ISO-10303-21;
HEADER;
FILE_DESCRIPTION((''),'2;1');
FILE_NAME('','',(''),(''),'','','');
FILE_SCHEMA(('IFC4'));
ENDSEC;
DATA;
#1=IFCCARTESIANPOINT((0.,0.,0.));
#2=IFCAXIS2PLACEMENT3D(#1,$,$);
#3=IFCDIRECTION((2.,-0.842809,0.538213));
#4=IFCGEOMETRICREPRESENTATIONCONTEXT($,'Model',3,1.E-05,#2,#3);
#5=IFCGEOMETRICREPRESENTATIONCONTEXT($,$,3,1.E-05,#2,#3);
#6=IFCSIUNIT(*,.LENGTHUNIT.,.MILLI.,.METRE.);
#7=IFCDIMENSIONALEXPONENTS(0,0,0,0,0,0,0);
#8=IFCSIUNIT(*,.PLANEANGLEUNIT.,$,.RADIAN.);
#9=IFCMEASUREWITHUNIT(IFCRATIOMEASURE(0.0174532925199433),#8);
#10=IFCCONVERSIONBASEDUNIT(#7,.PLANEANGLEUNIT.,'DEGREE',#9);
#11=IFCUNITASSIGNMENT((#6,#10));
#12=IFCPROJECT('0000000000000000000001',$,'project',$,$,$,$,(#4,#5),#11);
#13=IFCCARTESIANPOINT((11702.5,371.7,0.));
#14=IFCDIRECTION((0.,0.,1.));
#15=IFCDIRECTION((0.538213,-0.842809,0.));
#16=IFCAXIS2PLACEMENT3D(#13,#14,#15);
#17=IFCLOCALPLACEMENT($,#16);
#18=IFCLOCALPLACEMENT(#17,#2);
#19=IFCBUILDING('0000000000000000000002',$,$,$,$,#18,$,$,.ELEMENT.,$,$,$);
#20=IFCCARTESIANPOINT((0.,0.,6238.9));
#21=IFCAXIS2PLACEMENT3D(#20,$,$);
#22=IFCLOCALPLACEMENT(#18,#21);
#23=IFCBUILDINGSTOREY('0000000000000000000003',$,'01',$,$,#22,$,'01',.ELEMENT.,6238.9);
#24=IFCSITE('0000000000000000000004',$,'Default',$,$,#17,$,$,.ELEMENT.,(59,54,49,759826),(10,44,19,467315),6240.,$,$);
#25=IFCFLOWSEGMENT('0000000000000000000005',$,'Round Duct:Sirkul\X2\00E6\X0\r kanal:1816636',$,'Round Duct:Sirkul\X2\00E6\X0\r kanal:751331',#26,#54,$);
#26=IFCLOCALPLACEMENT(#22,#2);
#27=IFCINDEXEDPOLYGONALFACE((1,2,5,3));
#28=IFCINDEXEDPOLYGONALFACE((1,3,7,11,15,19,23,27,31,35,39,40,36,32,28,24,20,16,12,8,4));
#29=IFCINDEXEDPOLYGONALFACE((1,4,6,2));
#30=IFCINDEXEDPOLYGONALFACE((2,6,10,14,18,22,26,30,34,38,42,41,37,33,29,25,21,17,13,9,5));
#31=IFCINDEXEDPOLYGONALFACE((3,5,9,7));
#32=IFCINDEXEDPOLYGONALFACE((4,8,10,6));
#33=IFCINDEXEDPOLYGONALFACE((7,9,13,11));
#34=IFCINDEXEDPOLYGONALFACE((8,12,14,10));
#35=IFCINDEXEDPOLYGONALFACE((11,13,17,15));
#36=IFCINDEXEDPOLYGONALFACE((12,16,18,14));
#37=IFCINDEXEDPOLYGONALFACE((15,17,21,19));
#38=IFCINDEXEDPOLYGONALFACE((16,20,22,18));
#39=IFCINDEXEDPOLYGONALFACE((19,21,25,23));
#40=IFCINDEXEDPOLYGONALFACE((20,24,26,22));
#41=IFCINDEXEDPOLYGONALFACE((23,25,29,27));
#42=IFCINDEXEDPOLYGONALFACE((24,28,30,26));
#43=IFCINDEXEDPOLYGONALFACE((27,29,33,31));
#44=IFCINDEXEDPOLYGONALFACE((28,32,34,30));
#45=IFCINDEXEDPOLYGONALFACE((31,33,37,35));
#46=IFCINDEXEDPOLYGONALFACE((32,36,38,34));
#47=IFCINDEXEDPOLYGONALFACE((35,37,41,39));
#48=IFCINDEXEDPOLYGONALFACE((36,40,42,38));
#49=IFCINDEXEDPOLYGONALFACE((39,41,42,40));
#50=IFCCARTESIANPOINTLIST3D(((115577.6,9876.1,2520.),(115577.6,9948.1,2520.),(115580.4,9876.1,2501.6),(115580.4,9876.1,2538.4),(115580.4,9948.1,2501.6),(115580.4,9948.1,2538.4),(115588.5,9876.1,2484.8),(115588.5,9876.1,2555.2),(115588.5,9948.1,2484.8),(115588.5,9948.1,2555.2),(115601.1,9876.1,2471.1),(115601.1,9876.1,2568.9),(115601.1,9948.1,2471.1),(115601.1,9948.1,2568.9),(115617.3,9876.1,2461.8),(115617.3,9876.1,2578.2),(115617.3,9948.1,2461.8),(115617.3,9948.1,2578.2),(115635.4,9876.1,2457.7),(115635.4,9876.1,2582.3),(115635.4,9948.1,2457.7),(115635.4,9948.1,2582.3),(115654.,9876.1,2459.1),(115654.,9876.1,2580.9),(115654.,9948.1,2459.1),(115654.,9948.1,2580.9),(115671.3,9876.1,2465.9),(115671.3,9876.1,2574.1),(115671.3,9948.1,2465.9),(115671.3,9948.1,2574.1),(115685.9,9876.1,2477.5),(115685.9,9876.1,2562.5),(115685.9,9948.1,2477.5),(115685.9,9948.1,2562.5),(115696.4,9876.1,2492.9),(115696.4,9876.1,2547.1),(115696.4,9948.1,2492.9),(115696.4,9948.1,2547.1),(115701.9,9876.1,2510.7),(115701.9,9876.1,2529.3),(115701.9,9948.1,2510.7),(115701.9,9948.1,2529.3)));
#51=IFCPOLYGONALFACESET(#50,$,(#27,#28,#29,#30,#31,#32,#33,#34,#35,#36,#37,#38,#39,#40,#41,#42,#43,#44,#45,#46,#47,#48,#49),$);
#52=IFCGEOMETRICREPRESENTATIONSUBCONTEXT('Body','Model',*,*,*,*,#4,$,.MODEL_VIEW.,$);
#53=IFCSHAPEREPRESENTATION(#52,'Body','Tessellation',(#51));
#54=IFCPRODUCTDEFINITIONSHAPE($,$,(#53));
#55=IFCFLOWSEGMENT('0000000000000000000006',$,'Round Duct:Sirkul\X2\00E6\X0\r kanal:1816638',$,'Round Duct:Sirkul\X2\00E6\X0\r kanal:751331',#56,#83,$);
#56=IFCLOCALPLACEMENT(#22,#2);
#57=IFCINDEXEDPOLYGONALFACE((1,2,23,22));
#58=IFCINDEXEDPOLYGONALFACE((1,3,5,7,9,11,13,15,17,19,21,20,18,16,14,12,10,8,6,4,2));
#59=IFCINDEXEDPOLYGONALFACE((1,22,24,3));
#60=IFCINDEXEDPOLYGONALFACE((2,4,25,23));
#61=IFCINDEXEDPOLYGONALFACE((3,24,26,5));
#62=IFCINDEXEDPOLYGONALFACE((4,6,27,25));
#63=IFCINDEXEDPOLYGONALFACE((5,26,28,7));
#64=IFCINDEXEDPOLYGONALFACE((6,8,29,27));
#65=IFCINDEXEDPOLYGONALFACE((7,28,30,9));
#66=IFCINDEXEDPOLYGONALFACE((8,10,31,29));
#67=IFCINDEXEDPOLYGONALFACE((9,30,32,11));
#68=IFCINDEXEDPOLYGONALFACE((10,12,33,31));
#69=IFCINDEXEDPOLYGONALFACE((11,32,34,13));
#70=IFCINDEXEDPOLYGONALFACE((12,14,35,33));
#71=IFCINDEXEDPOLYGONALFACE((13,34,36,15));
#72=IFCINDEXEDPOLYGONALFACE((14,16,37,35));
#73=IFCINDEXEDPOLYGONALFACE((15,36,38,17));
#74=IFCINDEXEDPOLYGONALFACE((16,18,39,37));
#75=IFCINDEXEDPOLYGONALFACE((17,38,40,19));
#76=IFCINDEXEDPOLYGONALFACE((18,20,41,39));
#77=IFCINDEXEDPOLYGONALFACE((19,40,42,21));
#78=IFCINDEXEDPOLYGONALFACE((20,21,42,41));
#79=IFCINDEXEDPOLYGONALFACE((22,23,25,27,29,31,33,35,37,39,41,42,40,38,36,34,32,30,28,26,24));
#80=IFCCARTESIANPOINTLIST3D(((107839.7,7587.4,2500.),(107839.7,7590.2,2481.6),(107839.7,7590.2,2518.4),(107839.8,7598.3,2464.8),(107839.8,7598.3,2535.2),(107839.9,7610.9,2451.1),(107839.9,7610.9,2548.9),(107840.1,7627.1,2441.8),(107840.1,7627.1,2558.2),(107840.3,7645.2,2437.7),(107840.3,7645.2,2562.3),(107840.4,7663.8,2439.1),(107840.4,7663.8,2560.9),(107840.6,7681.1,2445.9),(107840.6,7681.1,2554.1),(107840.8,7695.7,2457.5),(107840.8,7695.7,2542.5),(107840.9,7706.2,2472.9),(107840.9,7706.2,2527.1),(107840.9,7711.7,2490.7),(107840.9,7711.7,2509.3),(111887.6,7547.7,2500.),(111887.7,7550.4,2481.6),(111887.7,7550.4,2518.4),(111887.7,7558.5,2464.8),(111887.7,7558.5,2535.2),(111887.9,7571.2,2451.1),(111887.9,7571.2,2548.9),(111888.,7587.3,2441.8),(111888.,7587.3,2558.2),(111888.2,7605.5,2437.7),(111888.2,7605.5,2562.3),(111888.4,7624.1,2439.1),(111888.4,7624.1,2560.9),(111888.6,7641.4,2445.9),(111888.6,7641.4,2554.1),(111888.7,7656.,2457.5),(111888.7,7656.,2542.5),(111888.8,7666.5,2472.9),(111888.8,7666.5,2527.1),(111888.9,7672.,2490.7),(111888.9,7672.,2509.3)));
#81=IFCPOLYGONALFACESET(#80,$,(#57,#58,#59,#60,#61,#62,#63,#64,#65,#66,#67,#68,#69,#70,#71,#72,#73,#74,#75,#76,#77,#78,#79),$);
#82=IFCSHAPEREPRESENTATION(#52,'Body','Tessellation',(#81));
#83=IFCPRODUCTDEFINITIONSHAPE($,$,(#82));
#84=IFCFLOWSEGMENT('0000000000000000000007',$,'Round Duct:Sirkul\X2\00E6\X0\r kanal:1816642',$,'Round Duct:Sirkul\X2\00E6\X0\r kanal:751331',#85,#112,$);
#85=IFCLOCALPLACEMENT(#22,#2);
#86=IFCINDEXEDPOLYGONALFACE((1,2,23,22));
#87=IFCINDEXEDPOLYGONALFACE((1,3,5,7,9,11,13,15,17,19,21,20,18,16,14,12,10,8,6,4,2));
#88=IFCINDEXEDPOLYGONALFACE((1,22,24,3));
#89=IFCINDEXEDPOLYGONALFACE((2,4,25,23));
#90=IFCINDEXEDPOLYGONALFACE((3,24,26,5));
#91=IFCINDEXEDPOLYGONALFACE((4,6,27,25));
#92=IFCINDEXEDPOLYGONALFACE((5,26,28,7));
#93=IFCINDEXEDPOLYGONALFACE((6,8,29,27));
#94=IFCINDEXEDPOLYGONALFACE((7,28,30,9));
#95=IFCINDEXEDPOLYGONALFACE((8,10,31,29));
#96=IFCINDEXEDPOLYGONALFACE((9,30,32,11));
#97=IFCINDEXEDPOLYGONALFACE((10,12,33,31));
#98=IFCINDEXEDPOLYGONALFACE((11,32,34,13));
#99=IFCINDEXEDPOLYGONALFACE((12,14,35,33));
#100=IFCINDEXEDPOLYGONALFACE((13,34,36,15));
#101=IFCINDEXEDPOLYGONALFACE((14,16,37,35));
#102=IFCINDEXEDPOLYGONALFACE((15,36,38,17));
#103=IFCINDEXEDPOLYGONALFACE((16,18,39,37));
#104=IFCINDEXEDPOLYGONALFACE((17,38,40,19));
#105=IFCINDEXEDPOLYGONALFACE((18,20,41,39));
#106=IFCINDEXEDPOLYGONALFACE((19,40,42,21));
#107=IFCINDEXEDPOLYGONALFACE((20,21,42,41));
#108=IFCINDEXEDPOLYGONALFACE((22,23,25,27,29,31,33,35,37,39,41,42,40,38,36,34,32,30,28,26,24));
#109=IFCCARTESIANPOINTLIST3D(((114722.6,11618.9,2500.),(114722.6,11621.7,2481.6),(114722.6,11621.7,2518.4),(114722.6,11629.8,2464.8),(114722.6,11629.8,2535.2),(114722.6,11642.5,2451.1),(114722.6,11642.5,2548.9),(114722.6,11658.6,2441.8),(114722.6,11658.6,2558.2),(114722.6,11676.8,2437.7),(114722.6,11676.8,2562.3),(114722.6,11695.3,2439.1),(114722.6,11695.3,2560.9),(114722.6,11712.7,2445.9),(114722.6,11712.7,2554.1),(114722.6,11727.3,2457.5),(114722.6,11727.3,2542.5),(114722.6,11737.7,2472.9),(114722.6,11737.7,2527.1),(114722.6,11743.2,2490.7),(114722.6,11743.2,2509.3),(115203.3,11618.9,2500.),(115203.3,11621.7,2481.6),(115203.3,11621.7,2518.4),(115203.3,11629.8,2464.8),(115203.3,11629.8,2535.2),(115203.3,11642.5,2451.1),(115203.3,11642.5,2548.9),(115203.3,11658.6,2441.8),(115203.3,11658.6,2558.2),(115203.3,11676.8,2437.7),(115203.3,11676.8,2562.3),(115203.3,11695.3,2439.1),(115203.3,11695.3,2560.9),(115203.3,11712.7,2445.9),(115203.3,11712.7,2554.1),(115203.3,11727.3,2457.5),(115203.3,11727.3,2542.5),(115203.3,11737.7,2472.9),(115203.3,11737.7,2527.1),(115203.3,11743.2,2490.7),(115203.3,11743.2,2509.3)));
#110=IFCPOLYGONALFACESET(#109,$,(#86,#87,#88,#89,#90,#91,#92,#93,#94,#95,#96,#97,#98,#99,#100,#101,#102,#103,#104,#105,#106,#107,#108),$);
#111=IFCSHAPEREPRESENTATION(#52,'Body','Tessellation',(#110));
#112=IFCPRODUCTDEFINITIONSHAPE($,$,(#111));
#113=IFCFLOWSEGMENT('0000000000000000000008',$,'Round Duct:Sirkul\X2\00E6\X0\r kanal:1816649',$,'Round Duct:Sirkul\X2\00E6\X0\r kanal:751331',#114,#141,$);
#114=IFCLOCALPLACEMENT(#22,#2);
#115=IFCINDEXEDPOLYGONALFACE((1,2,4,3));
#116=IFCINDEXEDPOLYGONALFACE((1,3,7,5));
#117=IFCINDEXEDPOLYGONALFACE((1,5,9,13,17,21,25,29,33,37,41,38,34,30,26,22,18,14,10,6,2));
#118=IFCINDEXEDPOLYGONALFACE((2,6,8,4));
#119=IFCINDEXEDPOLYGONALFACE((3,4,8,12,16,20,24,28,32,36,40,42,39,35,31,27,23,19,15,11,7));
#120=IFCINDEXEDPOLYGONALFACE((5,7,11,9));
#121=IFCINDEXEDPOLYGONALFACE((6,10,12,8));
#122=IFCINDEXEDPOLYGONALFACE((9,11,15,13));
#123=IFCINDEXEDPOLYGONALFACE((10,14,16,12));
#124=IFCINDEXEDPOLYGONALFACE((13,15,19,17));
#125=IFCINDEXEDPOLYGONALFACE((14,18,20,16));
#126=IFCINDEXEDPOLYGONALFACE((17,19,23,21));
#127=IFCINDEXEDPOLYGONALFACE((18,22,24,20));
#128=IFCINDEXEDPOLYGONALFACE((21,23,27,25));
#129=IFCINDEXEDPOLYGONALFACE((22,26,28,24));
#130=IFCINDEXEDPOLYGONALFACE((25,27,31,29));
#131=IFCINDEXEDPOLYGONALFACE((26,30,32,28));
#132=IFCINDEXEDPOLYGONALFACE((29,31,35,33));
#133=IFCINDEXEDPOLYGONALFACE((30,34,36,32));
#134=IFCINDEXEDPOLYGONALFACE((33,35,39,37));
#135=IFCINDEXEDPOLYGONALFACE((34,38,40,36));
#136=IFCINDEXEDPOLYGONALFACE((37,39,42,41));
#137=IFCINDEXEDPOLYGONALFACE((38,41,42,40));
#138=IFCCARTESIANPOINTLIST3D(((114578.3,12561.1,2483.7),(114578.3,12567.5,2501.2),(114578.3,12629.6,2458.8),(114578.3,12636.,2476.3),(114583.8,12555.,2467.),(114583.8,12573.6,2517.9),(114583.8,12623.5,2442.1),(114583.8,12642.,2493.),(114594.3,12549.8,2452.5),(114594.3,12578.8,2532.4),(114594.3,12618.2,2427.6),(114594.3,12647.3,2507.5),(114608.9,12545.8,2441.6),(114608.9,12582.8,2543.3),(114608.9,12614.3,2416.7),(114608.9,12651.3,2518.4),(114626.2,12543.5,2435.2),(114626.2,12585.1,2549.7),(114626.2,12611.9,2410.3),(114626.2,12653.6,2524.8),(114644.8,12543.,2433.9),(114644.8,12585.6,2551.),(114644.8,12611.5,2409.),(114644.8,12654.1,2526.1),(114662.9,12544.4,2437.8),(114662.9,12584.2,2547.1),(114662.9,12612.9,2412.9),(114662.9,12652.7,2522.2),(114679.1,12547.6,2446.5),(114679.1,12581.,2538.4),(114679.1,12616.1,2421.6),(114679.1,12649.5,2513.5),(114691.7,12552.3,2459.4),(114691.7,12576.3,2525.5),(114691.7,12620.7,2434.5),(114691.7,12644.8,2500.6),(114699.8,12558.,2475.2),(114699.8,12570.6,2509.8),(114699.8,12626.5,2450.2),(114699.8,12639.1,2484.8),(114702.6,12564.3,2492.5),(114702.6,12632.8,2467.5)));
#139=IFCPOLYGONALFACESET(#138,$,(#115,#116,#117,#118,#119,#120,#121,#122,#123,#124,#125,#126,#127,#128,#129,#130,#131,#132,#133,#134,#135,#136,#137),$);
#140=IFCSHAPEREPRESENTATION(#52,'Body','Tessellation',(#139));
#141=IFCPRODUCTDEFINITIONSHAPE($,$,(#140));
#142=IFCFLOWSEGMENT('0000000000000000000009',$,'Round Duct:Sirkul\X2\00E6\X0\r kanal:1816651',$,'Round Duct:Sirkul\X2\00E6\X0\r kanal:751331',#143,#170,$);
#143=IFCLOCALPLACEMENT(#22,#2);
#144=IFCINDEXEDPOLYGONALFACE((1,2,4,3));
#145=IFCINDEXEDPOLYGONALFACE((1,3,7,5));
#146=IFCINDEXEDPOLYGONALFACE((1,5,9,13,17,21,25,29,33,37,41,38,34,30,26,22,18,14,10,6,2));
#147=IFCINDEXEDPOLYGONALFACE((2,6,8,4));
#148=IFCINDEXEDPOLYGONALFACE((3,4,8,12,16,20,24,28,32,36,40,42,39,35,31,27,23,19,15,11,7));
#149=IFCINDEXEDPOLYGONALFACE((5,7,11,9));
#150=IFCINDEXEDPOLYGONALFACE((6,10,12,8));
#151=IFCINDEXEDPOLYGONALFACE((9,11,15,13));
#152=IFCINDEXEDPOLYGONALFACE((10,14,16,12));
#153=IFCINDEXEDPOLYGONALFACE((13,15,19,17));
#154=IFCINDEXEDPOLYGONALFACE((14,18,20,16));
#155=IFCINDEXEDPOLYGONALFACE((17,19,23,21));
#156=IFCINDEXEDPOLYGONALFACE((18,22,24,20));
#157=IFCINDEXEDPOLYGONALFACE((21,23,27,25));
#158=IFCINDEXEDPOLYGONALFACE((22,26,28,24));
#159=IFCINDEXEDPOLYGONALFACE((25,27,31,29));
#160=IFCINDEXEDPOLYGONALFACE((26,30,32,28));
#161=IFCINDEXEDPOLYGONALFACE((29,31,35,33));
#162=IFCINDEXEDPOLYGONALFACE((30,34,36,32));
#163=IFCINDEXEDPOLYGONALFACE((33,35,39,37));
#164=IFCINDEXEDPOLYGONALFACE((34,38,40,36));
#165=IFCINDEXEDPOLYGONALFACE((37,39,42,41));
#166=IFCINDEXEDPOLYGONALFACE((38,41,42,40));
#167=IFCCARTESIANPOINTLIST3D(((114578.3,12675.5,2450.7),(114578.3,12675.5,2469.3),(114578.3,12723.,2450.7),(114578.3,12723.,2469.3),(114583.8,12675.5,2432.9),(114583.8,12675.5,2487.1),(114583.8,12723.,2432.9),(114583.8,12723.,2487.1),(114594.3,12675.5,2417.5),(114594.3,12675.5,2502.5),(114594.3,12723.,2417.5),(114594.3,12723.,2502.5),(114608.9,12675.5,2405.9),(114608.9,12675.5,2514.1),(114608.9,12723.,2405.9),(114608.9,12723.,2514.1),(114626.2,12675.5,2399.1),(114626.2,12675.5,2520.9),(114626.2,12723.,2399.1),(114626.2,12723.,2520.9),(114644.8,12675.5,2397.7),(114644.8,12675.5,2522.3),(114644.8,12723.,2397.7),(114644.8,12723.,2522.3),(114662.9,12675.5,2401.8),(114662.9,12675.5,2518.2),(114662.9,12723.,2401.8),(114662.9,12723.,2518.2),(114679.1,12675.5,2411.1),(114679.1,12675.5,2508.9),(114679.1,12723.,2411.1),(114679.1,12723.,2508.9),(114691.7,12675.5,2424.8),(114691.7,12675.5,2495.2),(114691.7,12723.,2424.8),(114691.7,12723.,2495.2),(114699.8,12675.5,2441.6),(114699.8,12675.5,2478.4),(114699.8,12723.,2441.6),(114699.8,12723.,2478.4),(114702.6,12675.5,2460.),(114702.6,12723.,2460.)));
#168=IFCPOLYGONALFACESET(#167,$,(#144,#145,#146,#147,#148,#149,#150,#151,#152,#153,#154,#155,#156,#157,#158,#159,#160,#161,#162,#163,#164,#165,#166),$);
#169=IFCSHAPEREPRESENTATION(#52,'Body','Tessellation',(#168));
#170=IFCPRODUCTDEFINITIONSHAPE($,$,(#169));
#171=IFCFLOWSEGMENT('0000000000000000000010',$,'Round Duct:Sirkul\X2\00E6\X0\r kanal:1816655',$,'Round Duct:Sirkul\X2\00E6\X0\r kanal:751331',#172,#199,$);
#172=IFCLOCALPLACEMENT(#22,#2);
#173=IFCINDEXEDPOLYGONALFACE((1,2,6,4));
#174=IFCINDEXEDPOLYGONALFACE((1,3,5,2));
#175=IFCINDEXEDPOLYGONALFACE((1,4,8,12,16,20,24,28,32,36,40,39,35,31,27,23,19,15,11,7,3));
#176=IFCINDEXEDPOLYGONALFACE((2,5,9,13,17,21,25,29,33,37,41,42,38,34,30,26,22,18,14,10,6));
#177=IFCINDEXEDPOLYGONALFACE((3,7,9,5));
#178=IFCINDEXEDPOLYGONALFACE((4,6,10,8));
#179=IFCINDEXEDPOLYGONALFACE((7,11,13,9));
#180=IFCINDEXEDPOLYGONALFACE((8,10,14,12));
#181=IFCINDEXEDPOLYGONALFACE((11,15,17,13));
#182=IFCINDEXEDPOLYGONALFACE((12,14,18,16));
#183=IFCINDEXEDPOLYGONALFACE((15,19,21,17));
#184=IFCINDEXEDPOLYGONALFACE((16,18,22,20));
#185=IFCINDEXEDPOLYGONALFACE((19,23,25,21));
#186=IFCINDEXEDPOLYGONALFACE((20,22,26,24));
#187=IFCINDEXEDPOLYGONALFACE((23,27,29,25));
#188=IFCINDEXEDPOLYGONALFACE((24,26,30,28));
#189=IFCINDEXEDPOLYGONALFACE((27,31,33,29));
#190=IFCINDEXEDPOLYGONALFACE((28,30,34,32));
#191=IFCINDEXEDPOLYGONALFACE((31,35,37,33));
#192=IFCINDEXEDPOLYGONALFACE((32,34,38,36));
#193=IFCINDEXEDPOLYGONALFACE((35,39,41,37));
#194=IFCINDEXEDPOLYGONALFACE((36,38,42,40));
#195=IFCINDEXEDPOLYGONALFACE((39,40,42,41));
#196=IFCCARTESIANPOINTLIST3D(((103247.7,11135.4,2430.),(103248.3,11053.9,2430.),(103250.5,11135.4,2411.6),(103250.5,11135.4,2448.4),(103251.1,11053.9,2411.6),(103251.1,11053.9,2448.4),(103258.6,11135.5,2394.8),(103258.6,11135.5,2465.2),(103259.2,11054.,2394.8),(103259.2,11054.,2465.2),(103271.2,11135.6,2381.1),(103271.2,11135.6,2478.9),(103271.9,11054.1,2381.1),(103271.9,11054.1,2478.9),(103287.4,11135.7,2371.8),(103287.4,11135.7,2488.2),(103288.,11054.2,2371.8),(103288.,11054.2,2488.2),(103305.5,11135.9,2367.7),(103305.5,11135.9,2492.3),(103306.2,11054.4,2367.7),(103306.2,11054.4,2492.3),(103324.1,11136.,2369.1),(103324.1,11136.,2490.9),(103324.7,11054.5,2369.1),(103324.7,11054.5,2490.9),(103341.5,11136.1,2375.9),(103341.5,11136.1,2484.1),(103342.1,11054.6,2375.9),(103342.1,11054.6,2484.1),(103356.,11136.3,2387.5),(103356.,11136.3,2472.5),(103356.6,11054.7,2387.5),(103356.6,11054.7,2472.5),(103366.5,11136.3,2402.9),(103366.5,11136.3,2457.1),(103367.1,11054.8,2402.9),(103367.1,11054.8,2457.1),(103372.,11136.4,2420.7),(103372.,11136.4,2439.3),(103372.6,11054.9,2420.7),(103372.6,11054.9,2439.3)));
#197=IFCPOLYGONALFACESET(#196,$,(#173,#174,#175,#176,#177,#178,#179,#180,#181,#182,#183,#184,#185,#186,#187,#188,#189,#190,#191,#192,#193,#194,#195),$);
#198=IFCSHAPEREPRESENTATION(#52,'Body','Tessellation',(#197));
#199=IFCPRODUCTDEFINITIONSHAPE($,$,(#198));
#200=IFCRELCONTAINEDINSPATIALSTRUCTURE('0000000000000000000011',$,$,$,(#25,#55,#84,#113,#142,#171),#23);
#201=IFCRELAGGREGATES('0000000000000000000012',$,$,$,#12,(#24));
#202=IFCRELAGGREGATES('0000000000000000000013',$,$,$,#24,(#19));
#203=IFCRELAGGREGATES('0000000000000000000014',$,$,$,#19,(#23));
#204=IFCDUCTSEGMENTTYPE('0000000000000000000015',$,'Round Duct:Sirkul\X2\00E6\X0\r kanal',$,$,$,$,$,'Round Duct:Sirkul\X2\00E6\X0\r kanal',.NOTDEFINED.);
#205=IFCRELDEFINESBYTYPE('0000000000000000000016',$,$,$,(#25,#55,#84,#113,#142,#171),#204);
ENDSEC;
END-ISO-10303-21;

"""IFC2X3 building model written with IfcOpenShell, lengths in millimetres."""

from ifc_helpers import new_model, entity, si_unit, converted_unit, direction, frame, frame_2d, origin, origin_2d_with_axis, place, context, subcontext, project, spatial, circle, extrude, type_object, element, save


model = new_model("IFC2X3")

# Units and contexts
model_context = context("Model", 3, precision=1e-05, world=origin(), true_north=direction((2.0, -0.842809, 0.538213)))
context_of_model = context(None, 3, precision=1e-05, world=origin(), true_north=direction((2.0, -0.842809, 0.538213)))
body_context = subcontext(model_context, "Body", "Model", "MODEL_VIEW")
ifc_project = project(units=[si_unit("LENGTHUNIT", "METRE", prefix="MILLI"), converted_unit("PLANEANGLEUNIT", "DEGREE", entity("IfcRatioMeasure", 0.0174532925199433), si_unit("PLANEANGLEUNIT", "RADIAN"), dimensions=[0, 0, 0, 0, 0, 0, 0])], contexts=[model_context, context_of_model])

# Site, building, storey
site_placement = place(None, frame((11702.5, 371.7, 0.0), z_axis=(0.0, 0.0, 1.0), x_axis=(0.538213, -0.842809, 0.0)))
site = spatial("IfcSite", under=ifc_project, at=site_placement, Name="Default", CompositionType="ELEMENT", RefLatitude=(59, 54, 49, 759826), RefLongitude=(10, 44, 19, 467315), RefElevation=6240.0)
building_placement = place(site_placement, origin())
building = spatial("IfcBuilding", under=site, at=building_placement, CompositionType="ELEMENT")
storey_placement = place(building_placement, frame((0.0, 0.0, 6238.9)))
storey = spatial("IfcBuildingStorey", under=building, at=storey_placement, Name="01", LongName="01", CompositionType="ELEMENT", Elevation=6238.9)

# Flow segments
duct_segment_type = type_object("IfcDuctSegmentType", Name="Round Duct:Sirkulær kanal", ElementType="Round Duct:Sirkulær kanal", PredefinedType="NOTDEFINED")
flow_segment_1_placement = place(storey_placement, origin())
element("IfcFlowSegment", 1, at=flow_segment_1_placement, inside=storey, type_object=duct_segment_type, Name="Round Duct:Sirkulær kanal:1816636", ObjectType="Round Duct:Sirkulær kanal:751331", context=body_context, shape_type="SweptSolid", body=[
    extrude(circle(Radius=62.5, at=origin_2d_with_axis()), frame((115640.1, 9876.1, 2520.0), z_axis=(0.000006, 1.0, 0.0), x_axis=(-1.0, 0.000006, 0.0)), (0.0, 0.0, 1.0), 72.0),
])
flow_segment_2_placement = place(storey_placement, origin())
element("IfcFlowSegment", 2, at=flow_segment_2_placement, inside=storey, type_object=duct_segment_type, Name="Round Duct:Sirkulær kanal:1816638", ObjectType="Round Duct:Sirkulær kanal:751331", context=body_context, shape_type="SweptSolid", body=[
    extrude(circle(Radius=62.5, at=frame_2d((0.0, 0.0), x_axis=(1.0, 0.0))), frame((111888.2, 7610.2, 2500.0), z_axis=(-0.999952, 0.009815, 0.0), x_axis=(-0.009815, -0.999952, 0.0)), (0.0, 0.0, 1.0), 4048.1),
])
flow_segment_3_placement = place(storey_placement, origin())
element("IfcFlowSegment", 3, at=flow_segment_3_placement, inside=storey, type_object=duct_segment_type, Name="Round Duct:Sirkulær kanal:1816642", ObjectType="Round Duct:Sirkulær kanal:751331", context=body_context, shape_type="SweptSolid", body=[
    extrude(circle(Radius=62.5, at=origin_2d_with_axis()), frame((114722.6, 11681.4, 2500.0), z_axis=(1.0, -0.000001, 0.0), x_axis=(-0.000001, -1.0, 0.0)), (0.0, 0.0, 1.0), 480.7),
])
flow_segment_4_placement = place(storey_placement, origin())
element("IfcFlowSegment", 4, at=flow_segment_4_placement, inside=storey, type_object=duct_segment_type, Name="Round Duct:Sirkulær kanal:1816649", ObjectType="Round Duct:Sirkulær kanal:751331", context=body_context, shape_type="SweptSolid", body=[
    extrude(circle(Radius=62.5, at=origin_2d_with_axis()), frame((114640.1, 12564.3, 2492.5), z_axis=(0.0, 0.939693, -0.34202), x_axis=(1.0, 0.0, 0.0)), (0.0, 0.0, 1.0), 72.9),
])
flow_segment_5_placement = place(storey_placement, origin())
element("IfcFlowSegment", 5, at=flow_segment_5_placement, inside=storey, type_object=duct_segment_type, Name="Round Duct:Sirkulær kanal:1816651", ObjectType="Round Duct:Sirkulær kanal:751331", context=body_context, shape_type="SweptSolid", body=[
    extrude(circle(Radius=62.5, at=frame_2d((0.0, 0.0), x_axis=(1.0, 0.0))), frame((114640.1, 12675.5, 2460.0), z_axis=(0.000011, 1.0, 0.0), x_axis=(1.0, -0.000011, 0.0)), (0.0, 0.0, 1.0), 47.5),
])
flow_segment_6_placement = place(storey_placement, origin())
element("IfcFlowSegment", 6, at=flow_segment_6_placement, inside=storey, type_object=duct_segment_type, Name="Round Duct:Sirkulær kanal:1816655", ObjectType="Round Duct:Sirkulær kanal:751331", context=body_context, shape_type="SweptSolid", body=[
    extrude(circle(Radius=62.5, at=origin_2d_with_axis()), frame((103310.2, 11135.9, 2430.0), z_axis=(0.007643, -0.999971, 0.0), x_axis=(-0.999971, -0.007643, 0.0)), (0.0, 0.0, 1.0), 81.5),
])

save(model, "model.ifc")
